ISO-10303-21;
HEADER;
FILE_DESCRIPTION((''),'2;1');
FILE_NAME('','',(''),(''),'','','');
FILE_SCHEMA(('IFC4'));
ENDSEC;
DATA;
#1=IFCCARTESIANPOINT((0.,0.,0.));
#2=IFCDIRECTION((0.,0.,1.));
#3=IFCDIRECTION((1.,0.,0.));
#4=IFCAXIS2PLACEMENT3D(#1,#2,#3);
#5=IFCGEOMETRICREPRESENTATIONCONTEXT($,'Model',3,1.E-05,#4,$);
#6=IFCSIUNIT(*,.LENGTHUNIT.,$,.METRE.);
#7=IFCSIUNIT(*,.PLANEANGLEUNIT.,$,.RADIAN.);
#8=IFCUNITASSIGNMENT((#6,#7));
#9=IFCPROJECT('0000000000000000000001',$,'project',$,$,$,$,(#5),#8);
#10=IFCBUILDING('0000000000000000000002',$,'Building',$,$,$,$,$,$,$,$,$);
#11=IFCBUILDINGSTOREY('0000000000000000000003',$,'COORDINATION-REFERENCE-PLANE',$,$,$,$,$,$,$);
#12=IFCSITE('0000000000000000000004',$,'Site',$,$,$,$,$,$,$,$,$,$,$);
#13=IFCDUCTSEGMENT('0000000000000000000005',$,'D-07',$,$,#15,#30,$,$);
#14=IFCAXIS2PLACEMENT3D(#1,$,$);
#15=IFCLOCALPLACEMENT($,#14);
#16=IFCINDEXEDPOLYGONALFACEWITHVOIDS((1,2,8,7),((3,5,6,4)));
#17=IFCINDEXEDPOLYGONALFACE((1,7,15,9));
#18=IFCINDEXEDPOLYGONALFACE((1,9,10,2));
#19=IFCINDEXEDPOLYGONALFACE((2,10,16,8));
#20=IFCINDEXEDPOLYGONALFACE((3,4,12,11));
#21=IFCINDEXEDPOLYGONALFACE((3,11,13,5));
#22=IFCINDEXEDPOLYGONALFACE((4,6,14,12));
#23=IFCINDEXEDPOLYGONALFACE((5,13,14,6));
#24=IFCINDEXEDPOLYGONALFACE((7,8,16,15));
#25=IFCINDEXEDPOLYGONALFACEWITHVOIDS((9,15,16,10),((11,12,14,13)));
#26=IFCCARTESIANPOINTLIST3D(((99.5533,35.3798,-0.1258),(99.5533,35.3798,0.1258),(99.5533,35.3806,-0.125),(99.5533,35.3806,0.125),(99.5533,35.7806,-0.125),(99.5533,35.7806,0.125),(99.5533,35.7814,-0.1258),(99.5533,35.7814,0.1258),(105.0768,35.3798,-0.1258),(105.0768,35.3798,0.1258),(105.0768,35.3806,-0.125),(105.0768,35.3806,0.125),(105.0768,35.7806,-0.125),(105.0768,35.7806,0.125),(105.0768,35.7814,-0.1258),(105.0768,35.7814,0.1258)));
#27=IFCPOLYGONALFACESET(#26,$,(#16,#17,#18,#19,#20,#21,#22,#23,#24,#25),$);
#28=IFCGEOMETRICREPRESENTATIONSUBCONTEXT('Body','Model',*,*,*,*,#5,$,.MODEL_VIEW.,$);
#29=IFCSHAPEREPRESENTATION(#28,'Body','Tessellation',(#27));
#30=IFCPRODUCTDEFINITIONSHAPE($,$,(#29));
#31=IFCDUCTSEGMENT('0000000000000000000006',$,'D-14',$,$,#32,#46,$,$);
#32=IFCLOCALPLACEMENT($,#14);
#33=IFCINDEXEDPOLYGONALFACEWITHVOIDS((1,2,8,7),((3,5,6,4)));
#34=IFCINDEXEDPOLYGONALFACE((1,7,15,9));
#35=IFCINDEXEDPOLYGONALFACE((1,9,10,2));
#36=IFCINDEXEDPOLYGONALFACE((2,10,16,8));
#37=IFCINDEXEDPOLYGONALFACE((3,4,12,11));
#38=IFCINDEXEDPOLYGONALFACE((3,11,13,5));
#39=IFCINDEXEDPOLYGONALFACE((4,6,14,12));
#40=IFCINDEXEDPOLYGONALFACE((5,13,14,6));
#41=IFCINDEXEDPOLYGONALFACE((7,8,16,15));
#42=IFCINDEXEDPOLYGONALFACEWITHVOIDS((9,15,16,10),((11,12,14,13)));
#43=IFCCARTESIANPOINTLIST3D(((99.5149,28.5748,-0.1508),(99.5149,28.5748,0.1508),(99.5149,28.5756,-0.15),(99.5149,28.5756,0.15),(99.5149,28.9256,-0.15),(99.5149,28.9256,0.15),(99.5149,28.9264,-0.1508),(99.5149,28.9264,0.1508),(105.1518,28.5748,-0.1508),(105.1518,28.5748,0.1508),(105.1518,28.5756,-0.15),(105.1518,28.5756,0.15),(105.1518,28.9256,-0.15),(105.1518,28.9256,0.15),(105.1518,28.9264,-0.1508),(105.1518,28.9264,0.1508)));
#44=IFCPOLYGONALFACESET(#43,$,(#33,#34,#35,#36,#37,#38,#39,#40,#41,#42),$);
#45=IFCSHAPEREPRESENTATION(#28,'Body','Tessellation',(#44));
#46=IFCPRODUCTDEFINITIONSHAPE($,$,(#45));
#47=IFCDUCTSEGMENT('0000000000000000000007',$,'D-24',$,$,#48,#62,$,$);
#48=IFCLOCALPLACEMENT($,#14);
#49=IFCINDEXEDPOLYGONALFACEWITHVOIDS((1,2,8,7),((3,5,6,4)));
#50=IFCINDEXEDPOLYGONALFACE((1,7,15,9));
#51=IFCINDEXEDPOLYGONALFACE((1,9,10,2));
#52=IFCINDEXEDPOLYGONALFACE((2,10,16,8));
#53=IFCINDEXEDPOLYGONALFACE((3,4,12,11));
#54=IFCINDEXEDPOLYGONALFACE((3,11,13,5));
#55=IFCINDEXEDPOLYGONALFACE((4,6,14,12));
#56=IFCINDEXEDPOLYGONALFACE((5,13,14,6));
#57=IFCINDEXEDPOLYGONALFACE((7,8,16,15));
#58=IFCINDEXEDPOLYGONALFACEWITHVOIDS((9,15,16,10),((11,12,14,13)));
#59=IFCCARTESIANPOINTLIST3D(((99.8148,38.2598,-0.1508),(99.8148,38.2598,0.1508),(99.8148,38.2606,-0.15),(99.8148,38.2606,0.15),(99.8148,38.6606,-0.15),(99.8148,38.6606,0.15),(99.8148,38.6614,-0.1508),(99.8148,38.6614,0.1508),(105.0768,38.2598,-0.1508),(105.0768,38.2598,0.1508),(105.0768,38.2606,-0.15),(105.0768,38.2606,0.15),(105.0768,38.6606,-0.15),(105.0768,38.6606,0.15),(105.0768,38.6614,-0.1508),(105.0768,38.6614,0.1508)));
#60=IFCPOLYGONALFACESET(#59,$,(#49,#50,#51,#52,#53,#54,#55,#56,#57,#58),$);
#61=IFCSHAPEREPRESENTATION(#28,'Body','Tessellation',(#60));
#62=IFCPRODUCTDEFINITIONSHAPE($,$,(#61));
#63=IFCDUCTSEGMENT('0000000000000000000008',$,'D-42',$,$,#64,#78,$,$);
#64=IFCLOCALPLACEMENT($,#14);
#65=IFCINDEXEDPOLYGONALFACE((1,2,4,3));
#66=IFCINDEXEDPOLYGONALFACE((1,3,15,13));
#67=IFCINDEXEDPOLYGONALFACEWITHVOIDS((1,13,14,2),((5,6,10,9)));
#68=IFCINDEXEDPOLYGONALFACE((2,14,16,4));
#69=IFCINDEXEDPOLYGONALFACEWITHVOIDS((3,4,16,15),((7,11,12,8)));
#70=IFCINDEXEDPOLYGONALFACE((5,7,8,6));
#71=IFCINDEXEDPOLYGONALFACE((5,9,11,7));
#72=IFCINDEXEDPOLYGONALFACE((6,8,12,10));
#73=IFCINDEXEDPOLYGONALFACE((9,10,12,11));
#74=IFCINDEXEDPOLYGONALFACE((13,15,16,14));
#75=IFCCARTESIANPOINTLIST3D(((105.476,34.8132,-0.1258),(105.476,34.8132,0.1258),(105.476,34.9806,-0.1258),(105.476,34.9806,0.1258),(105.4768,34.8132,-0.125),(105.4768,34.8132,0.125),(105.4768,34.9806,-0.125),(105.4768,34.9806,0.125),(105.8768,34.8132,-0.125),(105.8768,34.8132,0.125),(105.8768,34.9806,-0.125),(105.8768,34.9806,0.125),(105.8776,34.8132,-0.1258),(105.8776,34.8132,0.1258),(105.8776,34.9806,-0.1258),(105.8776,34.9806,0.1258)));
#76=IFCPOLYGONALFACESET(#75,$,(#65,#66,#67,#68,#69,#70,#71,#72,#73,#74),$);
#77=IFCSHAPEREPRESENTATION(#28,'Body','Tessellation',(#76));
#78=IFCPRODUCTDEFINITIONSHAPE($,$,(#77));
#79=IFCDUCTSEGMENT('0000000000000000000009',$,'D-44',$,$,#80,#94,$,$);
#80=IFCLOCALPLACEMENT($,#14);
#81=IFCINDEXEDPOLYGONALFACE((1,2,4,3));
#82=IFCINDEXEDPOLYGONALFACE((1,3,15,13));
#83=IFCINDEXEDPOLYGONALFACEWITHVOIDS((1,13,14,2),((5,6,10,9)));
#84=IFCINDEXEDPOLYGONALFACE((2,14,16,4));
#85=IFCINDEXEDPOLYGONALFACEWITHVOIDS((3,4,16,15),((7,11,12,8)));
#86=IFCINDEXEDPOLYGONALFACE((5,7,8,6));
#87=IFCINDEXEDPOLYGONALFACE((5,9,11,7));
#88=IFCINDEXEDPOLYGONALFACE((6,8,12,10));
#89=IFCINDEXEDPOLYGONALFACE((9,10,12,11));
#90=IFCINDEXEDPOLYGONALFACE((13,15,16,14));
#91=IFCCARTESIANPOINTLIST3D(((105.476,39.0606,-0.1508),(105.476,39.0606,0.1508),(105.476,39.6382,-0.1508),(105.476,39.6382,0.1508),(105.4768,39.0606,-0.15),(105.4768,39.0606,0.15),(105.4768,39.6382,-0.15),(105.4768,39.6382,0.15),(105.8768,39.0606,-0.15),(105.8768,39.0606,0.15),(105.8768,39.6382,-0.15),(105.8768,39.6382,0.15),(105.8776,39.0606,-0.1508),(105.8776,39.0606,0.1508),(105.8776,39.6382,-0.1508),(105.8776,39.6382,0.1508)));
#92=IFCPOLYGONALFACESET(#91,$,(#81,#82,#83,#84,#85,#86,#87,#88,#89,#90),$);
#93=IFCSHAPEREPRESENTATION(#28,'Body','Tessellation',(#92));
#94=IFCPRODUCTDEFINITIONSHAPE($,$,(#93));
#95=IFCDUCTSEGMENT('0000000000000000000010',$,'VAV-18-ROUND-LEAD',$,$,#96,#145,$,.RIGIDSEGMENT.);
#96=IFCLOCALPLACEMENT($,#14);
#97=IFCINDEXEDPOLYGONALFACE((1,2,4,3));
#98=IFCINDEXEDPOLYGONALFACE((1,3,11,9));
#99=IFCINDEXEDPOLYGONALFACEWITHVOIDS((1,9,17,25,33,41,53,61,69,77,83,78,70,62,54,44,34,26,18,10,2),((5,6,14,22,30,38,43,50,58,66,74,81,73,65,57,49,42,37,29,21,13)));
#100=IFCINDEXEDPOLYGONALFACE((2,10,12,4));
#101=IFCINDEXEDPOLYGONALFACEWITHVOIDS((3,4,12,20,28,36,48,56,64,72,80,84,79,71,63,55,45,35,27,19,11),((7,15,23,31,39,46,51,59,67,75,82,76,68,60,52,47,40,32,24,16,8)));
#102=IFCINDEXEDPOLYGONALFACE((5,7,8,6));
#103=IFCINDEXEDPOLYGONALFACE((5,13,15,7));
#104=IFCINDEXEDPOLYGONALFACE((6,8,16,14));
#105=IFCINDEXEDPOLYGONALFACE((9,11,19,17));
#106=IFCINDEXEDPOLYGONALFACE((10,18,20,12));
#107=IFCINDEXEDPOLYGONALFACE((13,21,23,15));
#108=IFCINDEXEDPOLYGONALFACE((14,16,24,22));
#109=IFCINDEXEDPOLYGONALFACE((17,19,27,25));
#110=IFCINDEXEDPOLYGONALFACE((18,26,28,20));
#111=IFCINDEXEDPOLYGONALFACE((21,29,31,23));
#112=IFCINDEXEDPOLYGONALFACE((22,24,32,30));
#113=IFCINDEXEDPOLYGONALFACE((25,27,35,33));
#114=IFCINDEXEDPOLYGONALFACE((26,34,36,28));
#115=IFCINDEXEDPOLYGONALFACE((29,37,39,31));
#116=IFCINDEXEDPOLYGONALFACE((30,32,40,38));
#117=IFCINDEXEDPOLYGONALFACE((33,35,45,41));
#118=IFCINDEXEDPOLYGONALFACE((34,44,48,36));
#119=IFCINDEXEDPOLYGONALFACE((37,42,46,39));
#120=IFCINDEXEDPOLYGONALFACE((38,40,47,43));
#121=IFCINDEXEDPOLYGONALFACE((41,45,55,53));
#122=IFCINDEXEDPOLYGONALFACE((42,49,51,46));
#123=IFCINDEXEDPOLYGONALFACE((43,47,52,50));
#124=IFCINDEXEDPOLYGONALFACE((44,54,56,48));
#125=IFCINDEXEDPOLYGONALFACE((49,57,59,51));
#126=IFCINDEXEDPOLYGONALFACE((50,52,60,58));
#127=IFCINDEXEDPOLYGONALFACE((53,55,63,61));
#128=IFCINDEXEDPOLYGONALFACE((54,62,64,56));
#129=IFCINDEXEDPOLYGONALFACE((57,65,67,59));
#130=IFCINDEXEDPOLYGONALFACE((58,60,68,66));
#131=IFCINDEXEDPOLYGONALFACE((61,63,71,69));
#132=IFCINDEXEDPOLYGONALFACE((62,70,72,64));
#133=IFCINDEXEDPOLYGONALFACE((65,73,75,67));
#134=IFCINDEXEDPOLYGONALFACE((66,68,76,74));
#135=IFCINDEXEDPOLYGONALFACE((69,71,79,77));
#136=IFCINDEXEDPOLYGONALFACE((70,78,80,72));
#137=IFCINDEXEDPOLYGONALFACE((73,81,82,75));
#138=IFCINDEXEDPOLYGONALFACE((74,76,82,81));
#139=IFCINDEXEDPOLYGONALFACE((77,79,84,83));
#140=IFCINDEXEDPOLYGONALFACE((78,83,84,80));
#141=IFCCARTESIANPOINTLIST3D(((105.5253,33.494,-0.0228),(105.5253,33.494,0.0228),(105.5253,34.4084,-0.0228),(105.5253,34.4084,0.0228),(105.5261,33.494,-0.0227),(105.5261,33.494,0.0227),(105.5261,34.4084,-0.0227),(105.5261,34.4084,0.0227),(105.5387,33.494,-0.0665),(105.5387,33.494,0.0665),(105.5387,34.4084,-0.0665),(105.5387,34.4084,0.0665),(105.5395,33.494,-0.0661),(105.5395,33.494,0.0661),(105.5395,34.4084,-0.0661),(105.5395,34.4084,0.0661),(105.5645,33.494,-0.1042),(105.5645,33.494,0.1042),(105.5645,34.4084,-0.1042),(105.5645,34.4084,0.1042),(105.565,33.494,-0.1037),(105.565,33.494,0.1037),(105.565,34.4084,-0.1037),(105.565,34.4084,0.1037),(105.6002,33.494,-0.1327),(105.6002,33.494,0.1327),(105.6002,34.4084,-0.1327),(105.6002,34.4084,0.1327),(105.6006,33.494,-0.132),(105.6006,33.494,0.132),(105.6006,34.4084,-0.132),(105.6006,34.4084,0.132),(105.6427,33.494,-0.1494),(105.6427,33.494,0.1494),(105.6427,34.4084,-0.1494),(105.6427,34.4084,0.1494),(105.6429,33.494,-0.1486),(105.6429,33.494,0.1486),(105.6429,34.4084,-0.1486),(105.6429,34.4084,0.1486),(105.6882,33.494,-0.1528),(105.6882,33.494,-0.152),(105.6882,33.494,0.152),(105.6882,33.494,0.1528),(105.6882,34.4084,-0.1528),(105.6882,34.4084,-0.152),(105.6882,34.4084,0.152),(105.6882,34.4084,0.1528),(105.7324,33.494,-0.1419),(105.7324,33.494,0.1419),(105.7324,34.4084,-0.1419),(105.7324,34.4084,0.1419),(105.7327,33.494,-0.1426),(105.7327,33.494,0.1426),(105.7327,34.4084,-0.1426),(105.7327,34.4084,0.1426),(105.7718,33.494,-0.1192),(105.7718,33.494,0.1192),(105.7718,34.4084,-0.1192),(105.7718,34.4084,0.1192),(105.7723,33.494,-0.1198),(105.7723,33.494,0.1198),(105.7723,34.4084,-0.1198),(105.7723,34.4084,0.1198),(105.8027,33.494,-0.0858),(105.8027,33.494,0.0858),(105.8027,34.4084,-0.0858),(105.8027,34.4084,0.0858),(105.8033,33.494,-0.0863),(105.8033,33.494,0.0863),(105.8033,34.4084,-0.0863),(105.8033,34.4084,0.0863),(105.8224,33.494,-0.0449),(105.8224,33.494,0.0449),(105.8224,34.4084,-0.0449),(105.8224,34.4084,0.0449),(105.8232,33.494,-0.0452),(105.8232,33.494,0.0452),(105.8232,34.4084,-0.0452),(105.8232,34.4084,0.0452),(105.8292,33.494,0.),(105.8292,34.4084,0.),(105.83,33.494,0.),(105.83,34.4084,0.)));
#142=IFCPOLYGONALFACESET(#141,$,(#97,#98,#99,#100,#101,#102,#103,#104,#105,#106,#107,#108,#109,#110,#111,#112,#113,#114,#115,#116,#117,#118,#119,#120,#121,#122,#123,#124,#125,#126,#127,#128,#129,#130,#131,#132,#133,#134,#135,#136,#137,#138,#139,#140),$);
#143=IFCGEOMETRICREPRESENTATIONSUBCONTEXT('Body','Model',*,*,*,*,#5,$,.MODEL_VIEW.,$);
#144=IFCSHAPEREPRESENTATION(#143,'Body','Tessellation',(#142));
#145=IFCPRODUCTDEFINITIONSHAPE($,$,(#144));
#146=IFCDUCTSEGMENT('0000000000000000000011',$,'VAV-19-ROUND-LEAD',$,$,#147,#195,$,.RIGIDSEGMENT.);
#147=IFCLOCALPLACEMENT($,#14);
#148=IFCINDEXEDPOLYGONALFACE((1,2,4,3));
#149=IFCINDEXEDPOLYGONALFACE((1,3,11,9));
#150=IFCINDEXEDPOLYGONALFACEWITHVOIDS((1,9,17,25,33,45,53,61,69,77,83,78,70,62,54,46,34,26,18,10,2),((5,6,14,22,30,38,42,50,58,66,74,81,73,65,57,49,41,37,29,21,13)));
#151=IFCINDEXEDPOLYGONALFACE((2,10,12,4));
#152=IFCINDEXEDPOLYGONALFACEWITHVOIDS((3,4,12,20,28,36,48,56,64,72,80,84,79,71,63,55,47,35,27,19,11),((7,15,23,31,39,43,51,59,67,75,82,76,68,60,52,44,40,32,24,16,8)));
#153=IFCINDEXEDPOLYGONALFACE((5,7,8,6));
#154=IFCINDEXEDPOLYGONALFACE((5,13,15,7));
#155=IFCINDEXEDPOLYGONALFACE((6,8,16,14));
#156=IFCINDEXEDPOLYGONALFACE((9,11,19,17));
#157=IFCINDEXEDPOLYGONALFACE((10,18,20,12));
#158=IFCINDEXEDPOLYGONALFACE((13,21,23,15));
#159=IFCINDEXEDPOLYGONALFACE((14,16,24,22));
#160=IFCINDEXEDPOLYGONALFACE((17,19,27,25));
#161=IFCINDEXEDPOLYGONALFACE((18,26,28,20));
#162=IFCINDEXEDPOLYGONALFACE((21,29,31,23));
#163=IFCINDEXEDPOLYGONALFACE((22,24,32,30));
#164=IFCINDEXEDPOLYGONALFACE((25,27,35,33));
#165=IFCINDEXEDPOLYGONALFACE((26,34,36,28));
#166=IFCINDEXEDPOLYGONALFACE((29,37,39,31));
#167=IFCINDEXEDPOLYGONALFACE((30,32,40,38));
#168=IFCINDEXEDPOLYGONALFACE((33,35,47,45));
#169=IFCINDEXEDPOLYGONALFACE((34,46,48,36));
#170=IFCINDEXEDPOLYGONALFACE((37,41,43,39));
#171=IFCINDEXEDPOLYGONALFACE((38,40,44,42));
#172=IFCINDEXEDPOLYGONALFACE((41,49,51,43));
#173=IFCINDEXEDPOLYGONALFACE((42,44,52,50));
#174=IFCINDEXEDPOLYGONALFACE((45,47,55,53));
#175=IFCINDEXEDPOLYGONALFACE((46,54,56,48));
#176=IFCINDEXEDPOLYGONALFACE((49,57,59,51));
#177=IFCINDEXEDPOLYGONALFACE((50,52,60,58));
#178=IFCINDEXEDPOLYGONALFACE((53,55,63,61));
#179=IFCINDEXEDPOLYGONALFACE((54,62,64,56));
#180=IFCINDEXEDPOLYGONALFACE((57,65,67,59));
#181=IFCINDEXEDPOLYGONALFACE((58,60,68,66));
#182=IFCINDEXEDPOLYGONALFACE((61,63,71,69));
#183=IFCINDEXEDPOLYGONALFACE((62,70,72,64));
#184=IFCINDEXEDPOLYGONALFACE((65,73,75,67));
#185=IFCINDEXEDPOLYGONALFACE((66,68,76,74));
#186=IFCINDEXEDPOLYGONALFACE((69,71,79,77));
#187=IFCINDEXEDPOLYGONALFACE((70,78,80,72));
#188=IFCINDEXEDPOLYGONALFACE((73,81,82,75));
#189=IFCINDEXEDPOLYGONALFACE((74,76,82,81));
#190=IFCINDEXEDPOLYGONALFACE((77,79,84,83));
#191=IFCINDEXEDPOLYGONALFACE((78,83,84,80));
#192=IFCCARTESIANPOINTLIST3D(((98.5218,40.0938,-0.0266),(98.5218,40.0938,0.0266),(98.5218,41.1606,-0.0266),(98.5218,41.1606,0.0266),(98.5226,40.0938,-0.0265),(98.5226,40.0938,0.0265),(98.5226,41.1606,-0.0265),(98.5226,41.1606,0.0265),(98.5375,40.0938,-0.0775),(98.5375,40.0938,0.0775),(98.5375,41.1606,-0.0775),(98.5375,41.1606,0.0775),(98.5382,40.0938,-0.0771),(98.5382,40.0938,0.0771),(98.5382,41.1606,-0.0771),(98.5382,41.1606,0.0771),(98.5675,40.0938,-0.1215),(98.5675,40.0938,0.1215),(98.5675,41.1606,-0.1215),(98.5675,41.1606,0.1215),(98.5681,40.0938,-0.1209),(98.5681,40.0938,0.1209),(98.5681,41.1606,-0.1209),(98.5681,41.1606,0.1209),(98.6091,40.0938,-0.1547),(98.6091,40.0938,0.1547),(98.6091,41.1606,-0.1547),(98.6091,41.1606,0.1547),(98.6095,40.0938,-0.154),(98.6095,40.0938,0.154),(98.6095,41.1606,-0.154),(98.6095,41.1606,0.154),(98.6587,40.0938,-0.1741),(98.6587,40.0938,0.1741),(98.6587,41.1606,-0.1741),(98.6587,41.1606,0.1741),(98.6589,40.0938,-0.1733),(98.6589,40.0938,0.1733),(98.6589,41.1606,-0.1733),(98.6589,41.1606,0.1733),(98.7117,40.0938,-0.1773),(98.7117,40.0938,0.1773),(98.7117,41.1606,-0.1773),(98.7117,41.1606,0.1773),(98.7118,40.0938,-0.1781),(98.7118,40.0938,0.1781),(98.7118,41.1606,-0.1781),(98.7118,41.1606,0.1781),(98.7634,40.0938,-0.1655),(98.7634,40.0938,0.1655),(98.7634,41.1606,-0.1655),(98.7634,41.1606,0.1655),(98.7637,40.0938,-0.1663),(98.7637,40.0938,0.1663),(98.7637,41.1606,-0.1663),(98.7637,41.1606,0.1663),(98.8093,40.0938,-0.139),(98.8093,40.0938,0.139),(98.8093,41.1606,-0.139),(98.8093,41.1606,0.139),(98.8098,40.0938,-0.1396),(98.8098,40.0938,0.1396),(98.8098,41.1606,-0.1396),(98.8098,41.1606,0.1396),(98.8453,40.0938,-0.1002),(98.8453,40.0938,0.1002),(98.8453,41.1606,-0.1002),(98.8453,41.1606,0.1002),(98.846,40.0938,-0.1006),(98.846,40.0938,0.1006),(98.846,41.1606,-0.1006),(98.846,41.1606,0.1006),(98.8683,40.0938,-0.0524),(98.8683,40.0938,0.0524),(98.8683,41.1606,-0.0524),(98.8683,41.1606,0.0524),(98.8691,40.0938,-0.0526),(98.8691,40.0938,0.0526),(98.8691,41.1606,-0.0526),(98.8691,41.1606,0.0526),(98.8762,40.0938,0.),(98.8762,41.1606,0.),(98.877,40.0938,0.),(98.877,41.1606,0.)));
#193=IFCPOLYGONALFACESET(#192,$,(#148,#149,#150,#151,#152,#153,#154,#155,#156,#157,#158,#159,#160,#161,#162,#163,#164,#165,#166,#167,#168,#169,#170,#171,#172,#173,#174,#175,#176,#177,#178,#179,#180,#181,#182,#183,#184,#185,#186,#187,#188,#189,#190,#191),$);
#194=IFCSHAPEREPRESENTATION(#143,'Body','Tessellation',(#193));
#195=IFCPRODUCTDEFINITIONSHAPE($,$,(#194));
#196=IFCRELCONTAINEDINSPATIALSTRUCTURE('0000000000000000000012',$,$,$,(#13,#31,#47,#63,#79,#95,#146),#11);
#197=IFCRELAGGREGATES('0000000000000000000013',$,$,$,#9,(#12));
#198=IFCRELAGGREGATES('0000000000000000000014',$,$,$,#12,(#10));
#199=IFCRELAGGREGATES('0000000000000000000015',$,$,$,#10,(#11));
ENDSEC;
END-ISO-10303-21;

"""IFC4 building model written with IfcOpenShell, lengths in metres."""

from ifc_helpers import new_model, si_unit, frame, origin, origin_with_axes, place, context, subcontext, project, spatial, hollow_rectangle, hollow_circle, extrude, element, save


model = new_model("IFC4")

# Units and contexts
model_context = context("Model", 3, precision=1e-05, world=origin_with_axes())
body_context_1 = subcontext(model_context, "Body", "Model", "MODEL_VIEW")
body_context_2 = subcontext(model_context, "Body", "Model", "MODEL_VIEW")
ifc_project = project(units=[si_unit("LENGTHUNIT", "METRE"), si_unit("PLANEANGLEUNIT", "RADIAN")], contexts=[model_context])

# Site, building, storey
site = spatial("IfcSite", under=ifc_project, Name="Site")
building = spatial("IfcBuilding", under=site, Name="Building")
storey = spatial("IfcBuildingStorey", under=building, Name="COORDINATION-REFERENCE-PLANE")

# Duct segments
duct_segment_1_placement = place(None, frame((99.5533, 35.5806, 0.0), z_axis=(1.0, 0.0, 0.0), x_axis=(0.0, 1.0, 0.0)))
element("IfcDuctSegment", 1, at=duct_segment_1_placement, inside=storey, Name="D-07", context=body_context_1, shape_type="SweptSolid", body=[
    extrude(hollow_rectangle(XDim=0.4016, YDim=0.2516, WallThickness=0.0008), origin(), (0.0, 0.0, 1.0), 5.5234),
])
duct_segment_2_placement = place(None, frame((99.5149, 28.7506, 0.0), z_axis=(1.0, 0.0, 0.0), x_axis=(0.0, 1.0, 0.0)))
element("IfcDuctSegment", 2, at=duct_segment_2_placement, inside=storey, Name="D-14", context=body_context_1, shape_type="SweptSolid", body=[
    extrude(hollow_rectangle(XDim=0.3516, YDim=0.3016, WallThickness=0.0008), origin(), (0.0, 0.0, 1.0), 5.6369),
])
duct_segment_3_placement = place(None, frame((99.8148, 38.4606, 0.0), z_axis=(1.0, 0.0, 0.0), x_axis=(0.0, 1.0, 0.0)))
element("IfcDuctSegment", 3, at=duct_segment_3_placement, inside=storey, Name="D-24", context=body_context_1, shape_type="SweptSolid", body=[
    extrude(hollow_rectangle(XDim=0.4016, YDim=0.3016, WallThickness=0.0008), origin(), (0.0, 0.0, 1.0), 5.2619),
])
duct_segment_4_placement = place(None, frame((105.6768, 34.8132, 0.0), z_axis=(0.0, 1.0, 0.0), x_axis=(1.0, 0.0, 0.0)))
element("IfcDuctSegment", 4, at=duct_segment_4_placement, inside=storey, Name="D-42", context=body_context_1, shape_type="SweptSolid", body=[
    extrude(hollow_rectangle(XDim=0.4016, YDim=0.2516, WallThickness=0.0008), origin(), (0.0, 0.0, 1.0), 0.1673),
])
duct_segment_5_placement = place(None, frame((105.6768, 39.0606, 0.0), z_axis=(0.0, 1.0, 0.0), x_axis=(1.0, 0.0, 0.0)))
element("IfcDuctSegment", 5, at=duct_segment_5_placement, inside=storey, Name="D-44", context=body_context_1, shape_type="SweptSolid", body=[
    extrude(hollow_rectangle(XDim=0.4016, YDim=0.3016, WallThickness=0.0008), origin(), (0.0, 0.0, 1.0), 0.5776),
])

# Duct segments
duct_segment_6_placement = place(None, frame((105.6768, 34.4084, 0.0), z_axis=(0.0, -1.0, 0.0), x_axis=(1.0, 0.0, 0.0)))
element("IfcDuctSegment", 6, at=duct_segment_6_placement, inside=storey, Name="VAV-18-ROUND-LEAD", PredefinedType="RIGIDSEGMENT", context=body_context_2, shape_type="SweptSolid", body=[
    extrude(hollow_circle(Radius=0.1532, WallThickness=0.0008), origin(), (0.0, 0.0, 1.0), 0.9144),
])
for number, where, z_axis, x_axis, name in (
    (7, (98.6984, 40.0938, 0.0), (0.0, 1.0, 0.0), (1.0, 0.0, 0.0), "VAV-19-ROUND-LEAD"),
):
    element("IfcDuctSegment", number, at=place(None, frame(where, z_axis=z_axis, x_axis=x_axis)), inside=storey, Name=name, PredefinedType="RIGIDSEGMENT", context=body_context_2, shape_type="SweptSolid", body=[
        extrude(hollow_circle(Radius=0.1786, WallThickness=0.0008), origin(), (0.0, 0.0, 1.0), 1.0668),
    ])

save(model, "model.ifc")
